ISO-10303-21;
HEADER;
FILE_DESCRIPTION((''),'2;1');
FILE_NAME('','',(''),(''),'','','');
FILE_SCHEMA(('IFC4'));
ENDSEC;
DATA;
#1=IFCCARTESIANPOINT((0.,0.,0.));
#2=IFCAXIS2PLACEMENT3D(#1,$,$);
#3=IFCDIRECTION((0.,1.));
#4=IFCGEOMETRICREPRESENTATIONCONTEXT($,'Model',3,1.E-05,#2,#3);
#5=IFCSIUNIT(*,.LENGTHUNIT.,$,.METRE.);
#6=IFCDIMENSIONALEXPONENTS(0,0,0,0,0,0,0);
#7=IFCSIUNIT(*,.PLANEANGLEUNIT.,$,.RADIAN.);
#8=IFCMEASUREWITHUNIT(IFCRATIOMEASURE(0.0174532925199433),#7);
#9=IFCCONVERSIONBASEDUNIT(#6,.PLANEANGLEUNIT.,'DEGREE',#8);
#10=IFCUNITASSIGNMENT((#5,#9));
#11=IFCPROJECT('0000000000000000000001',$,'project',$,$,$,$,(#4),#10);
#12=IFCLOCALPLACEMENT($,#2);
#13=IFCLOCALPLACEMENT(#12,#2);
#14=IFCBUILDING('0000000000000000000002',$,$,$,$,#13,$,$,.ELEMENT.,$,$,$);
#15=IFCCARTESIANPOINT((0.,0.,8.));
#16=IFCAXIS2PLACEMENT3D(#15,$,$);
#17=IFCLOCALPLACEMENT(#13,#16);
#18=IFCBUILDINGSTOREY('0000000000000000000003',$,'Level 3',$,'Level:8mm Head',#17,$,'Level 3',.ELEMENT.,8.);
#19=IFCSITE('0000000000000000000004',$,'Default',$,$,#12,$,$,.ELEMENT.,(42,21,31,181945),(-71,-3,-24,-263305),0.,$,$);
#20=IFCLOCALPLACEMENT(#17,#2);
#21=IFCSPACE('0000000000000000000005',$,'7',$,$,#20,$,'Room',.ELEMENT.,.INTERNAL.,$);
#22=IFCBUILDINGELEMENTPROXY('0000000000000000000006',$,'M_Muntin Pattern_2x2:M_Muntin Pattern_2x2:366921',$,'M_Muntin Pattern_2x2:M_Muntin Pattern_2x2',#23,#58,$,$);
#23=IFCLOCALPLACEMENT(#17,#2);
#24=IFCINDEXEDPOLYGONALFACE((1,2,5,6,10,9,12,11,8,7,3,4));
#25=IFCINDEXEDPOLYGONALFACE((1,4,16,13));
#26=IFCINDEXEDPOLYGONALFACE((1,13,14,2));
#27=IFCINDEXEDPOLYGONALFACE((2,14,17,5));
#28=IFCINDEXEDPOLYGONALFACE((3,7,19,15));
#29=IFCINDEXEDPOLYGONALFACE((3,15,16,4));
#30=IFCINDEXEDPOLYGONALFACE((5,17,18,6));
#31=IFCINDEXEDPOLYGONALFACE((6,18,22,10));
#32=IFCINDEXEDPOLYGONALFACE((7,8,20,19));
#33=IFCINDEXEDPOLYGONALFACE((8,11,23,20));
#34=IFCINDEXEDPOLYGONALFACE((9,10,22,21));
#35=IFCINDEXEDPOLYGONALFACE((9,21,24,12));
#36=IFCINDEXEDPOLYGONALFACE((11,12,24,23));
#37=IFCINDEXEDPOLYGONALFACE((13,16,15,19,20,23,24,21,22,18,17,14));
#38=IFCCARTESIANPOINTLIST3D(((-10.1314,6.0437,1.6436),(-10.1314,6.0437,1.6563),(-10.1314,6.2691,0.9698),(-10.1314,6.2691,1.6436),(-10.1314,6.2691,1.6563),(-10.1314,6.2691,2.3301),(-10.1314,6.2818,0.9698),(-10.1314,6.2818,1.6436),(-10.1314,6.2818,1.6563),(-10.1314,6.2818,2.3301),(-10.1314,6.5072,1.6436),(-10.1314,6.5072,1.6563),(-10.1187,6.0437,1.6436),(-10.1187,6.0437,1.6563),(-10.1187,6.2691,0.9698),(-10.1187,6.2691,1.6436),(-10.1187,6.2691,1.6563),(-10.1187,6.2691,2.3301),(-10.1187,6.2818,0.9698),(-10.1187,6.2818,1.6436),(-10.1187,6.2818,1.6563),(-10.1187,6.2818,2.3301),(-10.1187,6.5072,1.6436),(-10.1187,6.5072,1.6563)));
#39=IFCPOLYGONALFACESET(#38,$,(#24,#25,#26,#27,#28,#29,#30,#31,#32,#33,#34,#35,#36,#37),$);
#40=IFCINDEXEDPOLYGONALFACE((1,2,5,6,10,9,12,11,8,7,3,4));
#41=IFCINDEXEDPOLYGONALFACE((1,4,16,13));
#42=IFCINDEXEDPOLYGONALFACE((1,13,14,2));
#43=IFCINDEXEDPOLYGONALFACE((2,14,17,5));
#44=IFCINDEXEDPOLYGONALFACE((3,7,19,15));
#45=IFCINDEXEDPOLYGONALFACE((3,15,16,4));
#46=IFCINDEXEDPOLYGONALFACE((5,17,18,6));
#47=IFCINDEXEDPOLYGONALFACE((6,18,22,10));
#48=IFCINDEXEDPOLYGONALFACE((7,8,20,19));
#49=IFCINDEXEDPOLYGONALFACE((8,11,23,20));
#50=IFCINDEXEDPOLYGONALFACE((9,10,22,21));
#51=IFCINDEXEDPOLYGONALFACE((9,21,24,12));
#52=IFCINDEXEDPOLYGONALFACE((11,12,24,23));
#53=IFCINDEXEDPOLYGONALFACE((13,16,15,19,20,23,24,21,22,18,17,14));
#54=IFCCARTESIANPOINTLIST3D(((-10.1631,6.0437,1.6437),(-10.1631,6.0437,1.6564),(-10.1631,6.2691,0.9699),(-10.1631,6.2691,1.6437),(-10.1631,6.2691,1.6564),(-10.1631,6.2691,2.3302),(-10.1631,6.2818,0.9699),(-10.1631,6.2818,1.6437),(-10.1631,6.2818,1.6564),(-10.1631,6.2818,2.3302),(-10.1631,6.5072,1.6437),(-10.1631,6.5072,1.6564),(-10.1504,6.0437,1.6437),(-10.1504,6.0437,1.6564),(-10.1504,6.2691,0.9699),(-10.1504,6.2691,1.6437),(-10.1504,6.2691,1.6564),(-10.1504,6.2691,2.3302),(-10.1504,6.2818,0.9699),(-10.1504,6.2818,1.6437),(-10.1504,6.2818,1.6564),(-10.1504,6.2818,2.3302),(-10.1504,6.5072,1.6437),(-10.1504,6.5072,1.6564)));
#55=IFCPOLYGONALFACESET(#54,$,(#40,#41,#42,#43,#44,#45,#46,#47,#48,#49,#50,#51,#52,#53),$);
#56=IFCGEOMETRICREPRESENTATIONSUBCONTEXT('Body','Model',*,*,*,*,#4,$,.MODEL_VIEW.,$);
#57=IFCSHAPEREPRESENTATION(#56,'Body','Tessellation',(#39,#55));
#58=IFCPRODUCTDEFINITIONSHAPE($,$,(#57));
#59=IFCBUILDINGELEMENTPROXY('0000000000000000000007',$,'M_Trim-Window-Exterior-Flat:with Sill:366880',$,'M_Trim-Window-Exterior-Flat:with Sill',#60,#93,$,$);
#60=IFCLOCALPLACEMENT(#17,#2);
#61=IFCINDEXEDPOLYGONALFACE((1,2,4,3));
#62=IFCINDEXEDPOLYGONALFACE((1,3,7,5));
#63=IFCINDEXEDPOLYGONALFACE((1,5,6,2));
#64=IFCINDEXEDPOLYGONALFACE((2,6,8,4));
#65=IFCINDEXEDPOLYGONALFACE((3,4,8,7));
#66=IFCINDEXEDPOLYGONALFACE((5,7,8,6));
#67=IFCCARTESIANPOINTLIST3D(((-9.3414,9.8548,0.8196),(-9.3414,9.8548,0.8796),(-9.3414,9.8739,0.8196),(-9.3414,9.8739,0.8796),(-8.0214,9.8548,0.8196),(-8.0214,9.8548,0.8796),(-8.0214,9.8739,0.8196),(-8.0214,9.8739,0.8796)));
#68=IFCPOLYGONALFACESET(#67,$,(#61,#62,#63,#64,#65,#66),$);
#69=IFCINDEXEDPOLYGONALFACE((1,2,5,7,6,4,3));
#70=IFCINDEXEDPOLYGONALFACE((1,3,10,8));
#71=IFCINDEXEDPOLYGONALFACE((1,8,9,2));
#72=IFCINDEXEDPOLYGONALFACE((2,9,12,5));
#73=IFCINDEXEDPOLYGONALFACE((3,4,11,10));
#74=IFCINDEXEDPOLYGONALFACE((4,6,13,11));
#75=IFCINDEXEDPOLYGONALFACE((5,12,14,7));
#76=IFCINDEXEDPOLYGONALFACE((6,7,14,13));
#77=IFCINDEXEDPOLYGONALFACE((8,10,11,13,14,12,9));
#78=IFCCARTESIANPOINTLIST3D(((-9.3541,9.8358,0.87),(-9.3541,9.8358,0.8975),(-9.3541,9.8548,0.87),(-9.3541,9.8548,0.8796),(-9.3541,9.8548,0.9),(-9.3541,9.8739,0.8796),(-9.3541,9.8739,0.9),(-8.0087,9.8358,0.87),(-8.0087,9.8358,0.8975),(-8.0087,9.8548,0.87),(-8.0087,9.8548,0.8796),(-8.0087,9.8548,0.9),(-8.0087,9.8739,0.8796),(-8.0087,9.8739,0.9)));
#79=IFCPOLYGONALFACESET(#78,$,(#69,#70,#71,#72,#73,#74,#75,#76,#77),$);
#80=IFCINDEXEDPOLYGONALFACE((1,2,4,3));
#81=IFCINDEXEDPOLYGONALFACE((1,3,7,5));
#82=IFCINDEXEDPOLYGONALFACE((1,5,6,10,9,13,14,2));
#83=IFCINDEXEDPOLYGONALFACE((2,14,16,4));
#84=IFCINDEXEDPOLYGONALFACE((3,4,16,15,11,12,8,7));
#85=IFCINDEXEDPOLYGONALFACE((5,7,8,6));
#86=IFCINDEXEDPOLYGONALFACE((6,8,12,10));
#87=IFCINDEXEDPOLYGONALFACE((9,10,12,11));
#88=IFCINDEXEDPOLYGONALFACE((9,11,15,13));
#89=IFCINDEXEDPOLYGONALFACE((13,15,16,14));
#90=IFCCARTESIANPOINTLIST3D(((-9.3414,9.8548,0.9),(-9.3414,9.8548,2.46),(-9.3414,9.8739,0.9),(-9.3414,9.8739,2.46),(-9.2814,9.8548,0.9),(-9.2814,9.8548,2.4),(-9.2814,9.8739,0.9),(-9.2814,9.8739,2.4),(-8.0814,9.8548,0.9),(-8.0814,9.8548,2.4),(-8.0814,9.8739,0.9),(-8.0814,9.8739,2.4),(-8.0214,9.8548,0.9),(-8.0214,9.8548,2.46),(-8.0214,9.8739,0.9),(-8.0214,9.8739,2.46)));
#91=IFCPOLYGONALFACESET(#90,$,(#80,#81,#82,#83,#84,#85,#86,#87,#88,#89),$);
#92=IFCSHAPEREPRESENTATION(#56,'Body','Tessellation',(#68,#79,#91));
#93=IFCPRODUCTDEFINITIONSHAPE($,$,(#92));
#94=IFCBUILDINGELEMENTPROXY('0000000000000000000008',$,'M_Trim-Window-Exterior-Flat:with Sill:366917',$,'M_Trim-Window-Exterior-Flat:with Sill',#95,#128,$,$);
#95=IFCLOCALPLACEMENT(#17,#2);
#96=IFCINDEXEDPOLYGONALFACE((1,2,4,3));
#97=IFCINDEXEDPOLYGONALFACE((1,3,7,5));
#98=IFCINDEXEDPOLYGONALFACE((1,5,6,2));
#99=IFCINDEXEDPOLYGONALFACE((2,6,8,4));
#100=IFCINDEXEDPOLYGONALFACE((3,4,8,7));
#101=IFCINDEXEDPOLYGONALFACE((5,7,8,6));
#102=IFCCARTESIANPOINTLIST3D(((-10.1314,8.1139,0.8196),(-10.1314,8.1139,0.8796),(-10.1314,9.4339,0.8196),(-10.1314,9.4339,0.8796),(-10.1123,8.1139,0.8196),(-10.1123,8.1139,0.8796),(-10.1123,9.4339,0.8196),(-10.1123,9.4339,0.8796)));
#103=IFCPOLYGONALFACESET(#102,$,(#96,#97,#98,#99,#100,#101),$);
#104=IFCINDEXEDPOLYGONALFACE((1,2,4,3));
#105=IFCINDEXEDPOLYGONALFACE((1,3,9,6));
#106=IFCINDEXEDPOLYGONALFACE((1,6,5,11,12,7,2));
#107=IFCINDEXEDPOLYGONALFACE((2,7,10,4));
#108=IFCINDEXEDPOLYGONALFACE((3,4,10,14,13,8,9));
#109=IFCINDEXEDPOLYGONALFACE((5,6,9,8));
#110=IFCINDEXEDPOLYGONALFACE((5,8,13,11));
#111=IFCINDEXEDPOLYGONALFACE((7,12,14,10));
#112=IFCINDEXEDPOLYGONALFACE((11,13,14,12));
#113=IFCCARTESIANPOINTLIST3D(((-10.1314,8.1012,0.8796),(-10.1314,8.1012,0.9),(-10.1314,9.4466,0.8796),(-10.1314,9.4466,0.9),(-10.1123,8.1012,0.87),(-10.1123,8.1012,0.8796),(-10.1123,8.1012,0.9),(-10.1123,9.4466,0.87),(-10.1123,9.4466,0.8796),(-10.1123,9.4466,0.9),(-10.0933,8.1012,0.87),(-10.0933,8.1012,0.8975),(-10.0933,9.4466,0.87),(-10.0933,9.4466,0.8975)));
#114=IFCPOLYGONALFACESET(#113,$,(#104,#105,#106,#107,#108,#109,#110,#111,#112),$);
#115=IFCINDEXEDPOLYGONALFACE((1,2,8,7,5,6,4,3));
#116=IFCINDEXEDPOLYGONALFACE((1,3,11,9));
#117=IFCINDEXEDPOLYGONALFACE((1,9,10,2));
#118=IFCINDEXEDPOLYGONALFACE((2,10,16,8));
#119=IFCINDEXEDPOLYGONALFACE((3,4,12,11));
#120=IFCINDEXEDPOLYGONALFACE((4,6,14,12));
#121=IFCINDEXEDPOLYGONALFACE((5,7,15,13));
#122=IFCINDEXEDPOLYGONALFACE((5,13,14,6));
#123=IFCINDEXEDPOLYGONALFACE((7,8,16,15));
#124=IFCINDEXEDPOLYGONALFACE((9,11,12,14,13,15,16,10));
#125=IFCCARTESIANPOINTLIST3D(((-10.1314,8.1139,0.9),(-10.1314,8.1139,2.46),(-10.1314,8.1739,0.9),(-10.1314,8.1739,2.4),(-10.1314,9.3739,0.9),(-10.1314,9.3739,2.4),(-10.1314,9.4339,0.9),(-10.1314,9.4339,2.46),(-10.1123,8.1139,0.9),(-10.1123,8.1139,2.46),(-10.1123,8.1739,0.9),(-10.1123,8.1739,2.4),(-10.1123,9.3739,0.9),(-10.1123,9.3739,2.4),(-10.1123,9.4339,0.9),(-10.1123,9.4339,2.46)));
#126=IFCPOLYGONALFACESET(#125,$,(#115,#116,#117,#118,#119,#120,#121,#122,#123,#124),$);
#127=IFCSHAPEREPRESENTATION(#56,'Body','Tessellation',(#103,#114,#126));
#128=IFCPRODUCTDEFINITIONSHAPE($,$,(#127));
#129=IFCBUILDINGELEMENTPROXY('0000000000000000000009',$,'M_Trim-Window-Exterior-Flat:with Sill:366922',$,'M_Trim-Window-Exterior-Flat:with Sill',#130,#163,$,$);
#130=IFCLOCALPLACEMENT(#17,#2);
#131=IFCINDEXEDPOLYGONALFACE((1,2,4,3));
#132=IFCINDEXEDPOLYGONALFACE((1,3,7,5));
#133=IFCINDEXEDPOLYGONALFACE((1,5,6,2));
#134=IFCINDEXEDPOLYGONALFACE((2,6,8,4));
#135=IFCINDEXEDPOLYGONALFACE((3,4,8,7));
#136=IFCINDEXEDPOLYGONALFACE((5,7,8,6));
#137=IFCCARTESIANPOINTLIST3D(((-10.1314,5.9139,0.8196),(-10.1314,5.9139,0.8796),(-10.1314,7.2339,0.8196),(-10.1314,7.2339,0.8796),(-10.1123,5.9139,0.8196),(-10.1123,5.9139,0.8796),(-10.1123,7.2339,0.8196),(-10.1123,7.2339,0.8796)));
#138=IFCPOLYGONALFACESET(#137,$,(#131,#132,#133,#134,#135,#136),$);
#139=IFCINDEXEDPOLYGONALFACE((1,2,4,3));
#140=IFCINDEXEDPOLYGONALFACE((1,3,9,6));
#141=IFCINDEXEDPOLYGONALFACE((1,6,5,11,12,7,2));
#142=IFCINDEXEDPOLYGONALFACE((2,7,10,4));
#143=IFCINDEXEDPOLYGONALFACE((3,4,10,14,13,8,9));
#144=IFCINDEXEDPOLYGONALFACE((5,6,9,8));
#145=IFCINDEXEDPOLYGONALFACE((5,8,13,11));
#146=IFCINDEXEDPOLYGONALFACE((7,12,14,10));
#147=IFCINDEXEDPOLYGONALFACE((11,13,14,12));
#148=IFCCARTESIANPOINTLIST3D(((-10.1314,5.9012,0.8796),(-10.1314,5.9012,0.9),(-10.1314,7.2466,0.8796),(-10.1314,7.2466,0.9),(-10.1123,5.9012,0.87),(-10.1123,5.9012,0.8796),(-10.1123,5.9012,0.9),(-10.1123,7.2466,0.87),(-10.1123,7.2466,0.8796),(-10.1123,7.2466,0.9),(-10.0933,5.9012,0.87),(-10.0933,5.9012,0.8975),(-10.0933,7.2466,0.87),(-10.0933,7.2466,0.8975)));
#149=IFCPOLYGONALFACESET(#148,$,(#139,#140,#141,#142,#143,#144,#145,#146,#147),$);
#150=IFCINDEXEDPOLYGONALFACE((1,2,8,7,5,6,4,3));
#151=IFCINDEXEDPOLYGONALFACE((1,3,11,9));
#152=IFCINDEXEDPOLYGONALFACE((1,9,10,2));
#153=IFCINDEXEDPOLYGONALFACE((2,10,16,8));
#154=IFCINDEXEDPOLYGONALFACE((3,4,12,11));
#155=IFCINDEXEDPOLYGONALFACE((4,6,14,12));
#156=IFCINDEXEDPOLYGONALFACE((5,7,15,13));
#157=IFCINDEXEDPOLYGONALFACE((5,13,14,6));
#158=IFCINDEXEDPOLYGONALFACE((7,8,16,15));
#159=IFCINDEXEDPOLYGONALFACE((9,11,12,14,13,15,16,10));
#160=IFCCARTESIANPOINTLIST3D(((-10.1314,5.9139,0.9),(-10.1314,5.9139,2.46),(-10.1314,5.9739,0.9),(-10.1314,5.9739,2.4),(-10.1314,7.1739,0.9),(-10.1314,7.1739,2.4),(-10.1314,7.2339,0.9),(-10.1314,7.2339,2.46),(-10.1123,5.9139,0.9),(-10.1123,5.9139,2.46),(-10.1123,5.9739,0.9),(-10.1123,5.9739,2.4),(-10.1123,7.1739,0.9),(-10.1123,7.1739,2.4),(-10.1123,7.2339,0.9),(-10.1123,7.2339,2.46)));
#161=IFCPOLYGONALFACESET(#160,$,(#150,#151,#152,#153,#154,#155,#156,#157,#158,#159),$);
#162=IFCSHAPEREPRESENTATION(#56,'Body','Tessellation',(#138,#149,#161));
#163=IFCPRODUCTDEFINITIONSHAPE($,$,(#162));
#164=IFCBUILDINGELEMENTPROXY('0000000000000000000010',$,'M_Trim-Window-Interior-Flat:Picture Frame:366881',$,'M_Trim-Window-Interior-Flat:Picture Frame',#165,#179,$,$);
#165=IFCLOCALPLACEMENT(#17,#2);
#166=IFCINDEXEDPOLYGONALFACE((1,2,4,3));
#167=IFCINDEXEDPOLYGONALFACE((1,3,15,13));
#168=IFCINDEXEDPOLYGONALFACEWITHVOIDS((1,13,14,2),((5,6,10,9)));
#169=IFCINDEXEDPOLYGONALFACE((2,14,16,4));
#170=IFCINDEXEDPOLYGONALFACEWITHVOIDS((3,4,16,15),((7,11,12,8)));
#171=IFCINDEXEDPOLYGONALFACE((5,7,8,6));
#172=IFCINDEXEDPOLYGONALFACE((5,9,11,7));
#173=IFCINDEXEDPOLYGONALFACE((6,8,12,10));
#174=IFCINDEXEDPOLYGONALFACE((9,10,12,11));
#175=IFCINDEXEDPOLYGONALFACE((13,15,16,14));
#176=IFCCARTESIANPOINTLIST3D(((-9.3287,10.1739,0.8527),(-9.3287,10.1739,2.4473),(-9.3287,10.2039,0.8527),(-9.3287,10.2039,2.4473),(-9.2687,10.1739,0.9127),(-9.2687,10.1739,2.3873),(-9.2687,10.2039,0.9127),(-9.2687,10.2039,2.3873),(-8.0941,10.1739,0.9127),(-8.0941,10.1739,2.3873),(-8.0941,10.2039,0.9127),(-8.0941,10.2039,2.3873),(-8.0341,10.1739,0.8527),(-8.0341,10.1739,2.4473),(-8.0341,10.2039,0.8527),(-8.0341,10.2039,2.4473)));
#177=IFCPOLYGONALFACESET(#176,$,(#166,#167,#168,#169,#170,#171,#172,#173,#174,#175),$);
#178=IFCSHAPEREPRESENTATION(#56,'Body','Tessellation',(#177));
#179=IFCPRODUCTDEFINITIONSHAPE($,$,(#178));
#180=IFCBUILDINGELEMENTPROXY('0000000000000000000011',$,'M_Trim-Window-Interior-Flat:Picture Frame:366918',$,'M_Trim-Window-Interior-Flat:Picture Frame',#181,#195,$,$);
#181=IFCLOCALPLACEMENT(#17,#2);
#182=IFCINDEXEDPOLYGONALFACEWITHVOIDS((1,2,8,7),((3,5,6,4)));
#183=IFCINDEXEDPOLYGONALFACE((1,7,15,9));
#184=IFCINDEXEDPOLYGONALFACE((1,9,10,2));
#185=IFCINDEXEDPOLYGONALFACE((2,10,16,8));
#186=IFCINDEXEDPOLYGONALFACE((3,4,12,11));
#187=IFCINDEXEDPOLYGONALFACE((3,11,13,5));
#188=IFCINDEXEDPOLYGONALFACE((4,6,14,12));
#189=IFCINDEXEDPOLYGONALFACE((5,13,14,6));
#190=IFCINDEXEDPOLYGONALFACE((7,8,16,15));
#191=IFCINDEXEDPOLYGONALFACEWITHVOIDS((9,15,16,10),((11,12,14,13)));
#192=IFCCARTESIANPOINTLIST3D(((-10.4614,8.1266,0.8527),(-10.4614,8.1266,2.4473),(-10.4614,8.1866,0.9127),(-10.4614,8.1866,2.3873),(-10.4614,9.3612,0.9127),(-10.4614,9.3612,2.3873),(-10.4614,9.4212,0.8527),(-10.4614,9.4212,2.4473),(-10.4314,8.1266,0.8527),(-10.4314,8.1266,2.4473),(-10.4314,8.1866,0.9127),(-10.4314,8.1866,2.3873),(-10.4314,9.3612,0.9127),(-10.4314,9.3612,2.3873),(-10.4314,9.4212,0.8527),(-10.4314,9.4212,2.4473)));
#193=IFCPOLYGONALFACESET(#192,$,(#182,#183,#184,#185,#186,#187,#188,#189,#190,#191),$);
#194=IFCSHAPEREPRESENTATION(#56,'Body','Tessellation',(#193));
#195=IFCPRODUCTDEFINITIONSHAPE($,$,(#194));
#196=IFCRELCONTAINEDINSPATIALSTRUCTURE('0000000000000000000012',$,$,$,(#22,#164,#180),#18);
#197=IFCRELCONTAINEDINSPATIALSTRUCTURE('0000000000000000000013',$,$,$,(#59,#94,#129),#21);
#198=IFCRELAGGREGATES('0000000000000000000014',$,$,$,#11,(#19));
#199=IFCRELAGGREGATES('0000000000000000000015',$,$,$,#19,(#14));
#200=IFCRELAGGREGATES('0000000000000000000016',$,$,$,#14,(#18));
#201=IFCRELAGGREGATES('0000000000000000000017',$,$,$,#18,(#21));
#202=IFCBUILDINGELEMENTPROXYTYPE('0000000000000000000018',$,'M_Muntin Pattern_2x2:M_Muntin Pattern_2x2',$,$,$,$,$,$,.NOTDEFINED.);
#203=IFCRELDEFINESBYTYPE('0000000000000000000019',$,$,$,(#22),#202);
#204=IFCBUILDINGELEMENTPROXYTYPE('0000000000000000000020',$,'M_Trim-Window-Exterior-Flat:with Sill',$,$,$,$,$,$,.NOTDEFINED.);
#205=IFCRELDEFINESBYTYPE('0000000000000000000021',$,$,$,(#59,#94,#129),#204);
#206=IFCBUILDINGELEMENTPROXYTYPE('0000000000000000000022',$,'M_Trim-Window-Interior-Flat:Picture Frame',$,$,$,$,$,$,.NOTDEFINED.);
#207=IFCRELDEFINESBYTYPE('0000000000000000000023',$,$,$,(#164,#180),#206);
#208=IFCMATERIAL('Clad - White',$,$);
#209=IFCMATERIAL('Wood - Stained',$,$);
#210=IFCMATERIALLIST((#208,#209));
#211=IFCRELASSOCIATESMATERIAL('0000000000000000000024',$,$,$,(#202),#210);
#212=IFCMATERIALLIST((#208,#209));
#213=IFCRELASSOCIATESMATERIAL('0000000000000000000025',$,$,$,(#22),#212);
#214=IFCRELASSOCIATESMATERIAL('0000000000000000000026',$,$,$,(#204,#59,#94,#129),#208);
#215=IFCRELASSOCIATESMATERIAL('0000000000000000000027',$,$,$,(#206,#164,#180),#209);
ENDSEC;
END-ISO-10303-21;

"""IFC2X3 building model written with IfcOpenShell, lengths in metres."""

from ifc_helpers import new_model, entity, si_unit, converted_unit, direction, frame, frame_2d, origin, place, context, subcontext, project, spatial, polyline, rectangle, outline, extrude, source, transform, mapped, material, material_list, type_object, type_shapes, element, save


model = new_model("IFC2X3")

# Units and contexts
model_context = context("Model", 3, precision=1e-05, world=origin(), true_north=direction((0.0, 1.0)))
body_context = subcontext(model_context, "Body", "Model", "MODEL_VIEW")
ifc_project = project(units=[si_unit("LENGTHUNIT", "METRE"), converted_unit("PLANEANGLEUNIT", "DEGREE", entity("IfcRatioMeasure", 0.0174532925199433), si_unit("PLANEANGLEUNIT", "RADIAN"), dimensions=[0, 0, 0, 0, 0, 0, 0])], contexts=[model_context])

# Site, building, storey
site_placement = place(None, origin())
site = spatial("IfcSite", under=ifc_project, at=site_placement, Name="Default", CompositionType="ELEMENT", RefLatitude=(42, 21, 31, 181945), RefLongitude=(-71, -3, -24, -263305), RefElevation=0.0)
building_placement = place(site_placement, origin())
building = spatial("IfcBuilding", under=site, at=building_placement, CompositionType="ELEMENT")
storey_placement = place(building_placement, frame((0.0, 0.0, 8.0)))
storey = spatial("IfcBuildingStorey", under=building, at=storey_placement, Name="Level 3", ObjectType="Level:8mm Head", LongName="Level 3", CompositionType="ELEMENT", Elevation=8.0)

# Building element proxy
ifc_material_1 = material(Name="Clad - White")
ifc_material_2 = material(Name="Wood - Stained")
ifc_material_list_1 = material_list([ifc_material_1, ifc_material_2])
building_element_proxy_type_1 = type_object("IfcBuildingElementProxyType", Name="M_Muntin Pattern_2x2:M_Muntin Pattern_2x2", PredefinedType="NOTDEFINED", material=ifc_material_list_1)
shared_shape_1 = source(origin(), body_context, "Body", "SweptSolid", [
    extrude(outline(polyline([(0.0064, -0.0064), (0.6801, -0.0064), (0.6801, 0.0063), (0.0064, 0.0063), (0.0064, 0.2317), (-0.0063, 0.2317), (-0.0063, 0.0063), (-0.6802, 0.0063), (-0.6802, -0.0064), (-0.0063, -0.0064), (-0.0063, -0.2317), (0.0064, -0.2317), (0.0064, -0.0064)])), frame((0.0, -0.0222, 0.6801), z_axis=(0.0, 1.0, 0.0), x_axis=(0.0, 0.0, 1.0)), (0.0, 0.0, 1.0), 0.0127),
    extrude(outline(polyline([(0.0064, -0.0064), (0.6802, -0.0064), (0.6802, 0.0063), (0.0064, 0.0063), (0.0064, 0.2317), (-0.0063, 0.2317), (-0.0063, 0.0063), (-0.6802, 0.0063), (-0.6802, -0.0064), (-0.0063, -0.0064), (-0.0063, -0.2317), (0.0064, -0.2317), (0.0064, -0.0064)])), frame((0.0, 0.0095, 0.6802), z_axis=(0.0, 1.0, 0.0), x_axis=(0.0, 0.0, 1.0)), (0.0, 0.0, 1.0), 0.0127),
])
type_shapes(building_element_proxy_type_1, [shared_shape_1])
ifc_material_list_2 = material_list([ifc_material_1, ifc_material_2])
proxy_1_placement = place(storey_placement, frame((-10.1409, 6.2754, 0.9699), z_axis=(0.0, 0.0, 1.0), x_axis=(0.0, 1.0, 0.0)))
element("IfcBuildingElementProxy", 1, at=proxy_1_placement, inside=storey, type_object=building_element_proxy_type_1, material=ifc_material_list_2, Name="M_Muntin Pattern_2x2:M_Muntin Pattern_2x2:366921", ObjectType="M_Muntin Pattern_2x2:M_Muntin Pattern_2x2", context=body_context, shape_type="MappedRepresentation", body=[
    mapped(shared_shape_1, transform((0.0, 0.0, 0.0), scale=1.0)),
])

# Shared definitions
space_placement = place(storey_placement, origin())
space = spatial("IfcSpace", under=storey, at=space_placement, Name="7", LongName="Room", CompositionType="ELEMENT", InteriorOrExteriorSpace="INTERNAL")

# Building element proxies
building_element_proxy_type_2 = type_object("IfcBuildingElementProxyType", Name="M_Trim-Window-Exterior-Flat:with Sill", PredefinedType="NOTDEFINED", material=ifc_material_1)
shared_shape_2 = source(origin(), body_context, "Body", "SweptSolid", [
    extrude(rectangle(XDim=1.32, YDim=0.06, at=frame_2d((0.0, 0.0), x_axis=(1.0, 0.0))), frame((0.0, -1.5504, 0.0), z_axis=(0.0, 0.0, 1.0), x_axis=(-1.0, 0.0, 0.0)), (0.0, 0.0, 1.0), 0.0191),
    extrude(outline(polyline([(-0.019, -0.0152), (0.0, -0.0152), (0.0, -0.0057), (0.019, -0.0057), (0.019, 0.0148), (0.0, 0.0148), (-0.019, 0.0123), (-0.019, -0.0152)])), frame((-0.6727, -1.5148, 0.019), z_axis=(1.0, 0.0, 0.0), x_axis=(0.0, 0.0, -1.0)), (0.0, 0.0, 1.0), 1.3454),
    extrude(outline(polyline([(-0.795, -0.66), (0.765, -0.66), (0.765, -0.6), (-0.735, -0.6), (-0.735, 0.6), (0.765, 0.6), (0.765, 0.66), (-0.795, 0.66), (-0.795, -0.66)])), frame((0.0, -0.735, 0.0), z_axis=(0.0, 0.0, 1.0), x_axis=(0.0, -1.0, 0.0)), (0.0, 0.0, 1.0), 0.0191),
])
type_shapes(building_element_proxy_type_2, [shared_shape_2])
for number, where, z_axis, x_axis, name in (
    (2, (-8.6814, 9.8739, 2.4), (0.0, -1.0, 0.0), (1.0, 0.0, 0.0), "M_Trim-Window-Exterior-Flat:with Sill:366880"),
    (3, (-10.1314, 8.7739, 2.4), (1.0, 0.0, 0.0), (0.0, 1.0, 0.0), "M_Trim-Window-Exterior-Flat:with Sill:366917"),
    (4, (-10.1314, 6.5739, 2.4), (1.0, 0.0, 0.0), (0.0, 1.0, 0.0), "M_Trim-Window-Exterior-Flat:with Sill:366922"),
):
    element("IfcBuildingElementProxy", number, at=place(space_placement, frame(where, z_axis=z_axis, x_axis=x_axis)), inside=space, type_object=building_element_proxy_type_2, material=ifc_material_1, Name=name, ObjectType="M_Trim-Window-Exterior-Flat:with Sill", context=body_context, shape_type="MappedRepresentation", body=[
        mapped(shared_shape_2, transform((0.0, 0.0, 0.0), scale=1.0)),
    ])
building_element_proxy_type_3 = type_object("IfcBuildingElementProxyType", Name="M_Trim-Window-Interior-Flat:Picture Frame", PredefinedType="NOTDEFINED", material=ifc_material_2)
shared_shape_3 = source(origin(), body_context, "Body", "SweptSolid", [
    extrude(outline(polyline([(-0.6473, -0.7973), (0.6473, -0.7973), (0.6473, 0.7973), (-0.6473, 0.7973), (-0.6473, -0.7973)]), holes=[polyline([(-0.5873, -0.7373), (-0.5873, 0.7373), (0.5873, 0.7373), (0.5873, -0.7373), (-0.5873, -0.7373)])]), frame((0.0, -0.75, 0.0), z_axis=(0.0, 0.0, 1.0), x_axis=(-1.0, 0.0, 0.0)), (0.0, 0.0, 1.0), 0.03),
])
type_shapes(building_element_proxy_type_3, [shared_shape_3])
for number, where, z_axis, x_axis, name in (
    (5, (-8.6814, 10.1739, 2.4), (0.0, 1.0, 0.0), (-1.0, 0.0, 0.0), "M_Trim-Window-Interior-Flat:Picture Frame:366881"),
    (6, (-10.4314, 8.7739, 2.4), (-1.0, 0.0, 0.0), (0.0, -1.0, 0.0), "M_Trim-Window-Interior-Flat:Picture Frame:366918"),
):
    element("IfcBuildingElementProxy", number, at=place(storey_placement, frame(where, z_axis=z_axis, x_axis=x_axis)), inside=storey, type_object=building_element_proxy_type_3, material=ifc_material_2, Name=name, ObjectType="M_Trim-Window-Interior-Flat:Picture Frame", context=body_context, shape_type="MappedRepresentation", body=[
        mapped(shared_shape_3, transform((0.0, 0.0, 0.0), scale=1.0)),
    ])

save(model, "model.ifc")
